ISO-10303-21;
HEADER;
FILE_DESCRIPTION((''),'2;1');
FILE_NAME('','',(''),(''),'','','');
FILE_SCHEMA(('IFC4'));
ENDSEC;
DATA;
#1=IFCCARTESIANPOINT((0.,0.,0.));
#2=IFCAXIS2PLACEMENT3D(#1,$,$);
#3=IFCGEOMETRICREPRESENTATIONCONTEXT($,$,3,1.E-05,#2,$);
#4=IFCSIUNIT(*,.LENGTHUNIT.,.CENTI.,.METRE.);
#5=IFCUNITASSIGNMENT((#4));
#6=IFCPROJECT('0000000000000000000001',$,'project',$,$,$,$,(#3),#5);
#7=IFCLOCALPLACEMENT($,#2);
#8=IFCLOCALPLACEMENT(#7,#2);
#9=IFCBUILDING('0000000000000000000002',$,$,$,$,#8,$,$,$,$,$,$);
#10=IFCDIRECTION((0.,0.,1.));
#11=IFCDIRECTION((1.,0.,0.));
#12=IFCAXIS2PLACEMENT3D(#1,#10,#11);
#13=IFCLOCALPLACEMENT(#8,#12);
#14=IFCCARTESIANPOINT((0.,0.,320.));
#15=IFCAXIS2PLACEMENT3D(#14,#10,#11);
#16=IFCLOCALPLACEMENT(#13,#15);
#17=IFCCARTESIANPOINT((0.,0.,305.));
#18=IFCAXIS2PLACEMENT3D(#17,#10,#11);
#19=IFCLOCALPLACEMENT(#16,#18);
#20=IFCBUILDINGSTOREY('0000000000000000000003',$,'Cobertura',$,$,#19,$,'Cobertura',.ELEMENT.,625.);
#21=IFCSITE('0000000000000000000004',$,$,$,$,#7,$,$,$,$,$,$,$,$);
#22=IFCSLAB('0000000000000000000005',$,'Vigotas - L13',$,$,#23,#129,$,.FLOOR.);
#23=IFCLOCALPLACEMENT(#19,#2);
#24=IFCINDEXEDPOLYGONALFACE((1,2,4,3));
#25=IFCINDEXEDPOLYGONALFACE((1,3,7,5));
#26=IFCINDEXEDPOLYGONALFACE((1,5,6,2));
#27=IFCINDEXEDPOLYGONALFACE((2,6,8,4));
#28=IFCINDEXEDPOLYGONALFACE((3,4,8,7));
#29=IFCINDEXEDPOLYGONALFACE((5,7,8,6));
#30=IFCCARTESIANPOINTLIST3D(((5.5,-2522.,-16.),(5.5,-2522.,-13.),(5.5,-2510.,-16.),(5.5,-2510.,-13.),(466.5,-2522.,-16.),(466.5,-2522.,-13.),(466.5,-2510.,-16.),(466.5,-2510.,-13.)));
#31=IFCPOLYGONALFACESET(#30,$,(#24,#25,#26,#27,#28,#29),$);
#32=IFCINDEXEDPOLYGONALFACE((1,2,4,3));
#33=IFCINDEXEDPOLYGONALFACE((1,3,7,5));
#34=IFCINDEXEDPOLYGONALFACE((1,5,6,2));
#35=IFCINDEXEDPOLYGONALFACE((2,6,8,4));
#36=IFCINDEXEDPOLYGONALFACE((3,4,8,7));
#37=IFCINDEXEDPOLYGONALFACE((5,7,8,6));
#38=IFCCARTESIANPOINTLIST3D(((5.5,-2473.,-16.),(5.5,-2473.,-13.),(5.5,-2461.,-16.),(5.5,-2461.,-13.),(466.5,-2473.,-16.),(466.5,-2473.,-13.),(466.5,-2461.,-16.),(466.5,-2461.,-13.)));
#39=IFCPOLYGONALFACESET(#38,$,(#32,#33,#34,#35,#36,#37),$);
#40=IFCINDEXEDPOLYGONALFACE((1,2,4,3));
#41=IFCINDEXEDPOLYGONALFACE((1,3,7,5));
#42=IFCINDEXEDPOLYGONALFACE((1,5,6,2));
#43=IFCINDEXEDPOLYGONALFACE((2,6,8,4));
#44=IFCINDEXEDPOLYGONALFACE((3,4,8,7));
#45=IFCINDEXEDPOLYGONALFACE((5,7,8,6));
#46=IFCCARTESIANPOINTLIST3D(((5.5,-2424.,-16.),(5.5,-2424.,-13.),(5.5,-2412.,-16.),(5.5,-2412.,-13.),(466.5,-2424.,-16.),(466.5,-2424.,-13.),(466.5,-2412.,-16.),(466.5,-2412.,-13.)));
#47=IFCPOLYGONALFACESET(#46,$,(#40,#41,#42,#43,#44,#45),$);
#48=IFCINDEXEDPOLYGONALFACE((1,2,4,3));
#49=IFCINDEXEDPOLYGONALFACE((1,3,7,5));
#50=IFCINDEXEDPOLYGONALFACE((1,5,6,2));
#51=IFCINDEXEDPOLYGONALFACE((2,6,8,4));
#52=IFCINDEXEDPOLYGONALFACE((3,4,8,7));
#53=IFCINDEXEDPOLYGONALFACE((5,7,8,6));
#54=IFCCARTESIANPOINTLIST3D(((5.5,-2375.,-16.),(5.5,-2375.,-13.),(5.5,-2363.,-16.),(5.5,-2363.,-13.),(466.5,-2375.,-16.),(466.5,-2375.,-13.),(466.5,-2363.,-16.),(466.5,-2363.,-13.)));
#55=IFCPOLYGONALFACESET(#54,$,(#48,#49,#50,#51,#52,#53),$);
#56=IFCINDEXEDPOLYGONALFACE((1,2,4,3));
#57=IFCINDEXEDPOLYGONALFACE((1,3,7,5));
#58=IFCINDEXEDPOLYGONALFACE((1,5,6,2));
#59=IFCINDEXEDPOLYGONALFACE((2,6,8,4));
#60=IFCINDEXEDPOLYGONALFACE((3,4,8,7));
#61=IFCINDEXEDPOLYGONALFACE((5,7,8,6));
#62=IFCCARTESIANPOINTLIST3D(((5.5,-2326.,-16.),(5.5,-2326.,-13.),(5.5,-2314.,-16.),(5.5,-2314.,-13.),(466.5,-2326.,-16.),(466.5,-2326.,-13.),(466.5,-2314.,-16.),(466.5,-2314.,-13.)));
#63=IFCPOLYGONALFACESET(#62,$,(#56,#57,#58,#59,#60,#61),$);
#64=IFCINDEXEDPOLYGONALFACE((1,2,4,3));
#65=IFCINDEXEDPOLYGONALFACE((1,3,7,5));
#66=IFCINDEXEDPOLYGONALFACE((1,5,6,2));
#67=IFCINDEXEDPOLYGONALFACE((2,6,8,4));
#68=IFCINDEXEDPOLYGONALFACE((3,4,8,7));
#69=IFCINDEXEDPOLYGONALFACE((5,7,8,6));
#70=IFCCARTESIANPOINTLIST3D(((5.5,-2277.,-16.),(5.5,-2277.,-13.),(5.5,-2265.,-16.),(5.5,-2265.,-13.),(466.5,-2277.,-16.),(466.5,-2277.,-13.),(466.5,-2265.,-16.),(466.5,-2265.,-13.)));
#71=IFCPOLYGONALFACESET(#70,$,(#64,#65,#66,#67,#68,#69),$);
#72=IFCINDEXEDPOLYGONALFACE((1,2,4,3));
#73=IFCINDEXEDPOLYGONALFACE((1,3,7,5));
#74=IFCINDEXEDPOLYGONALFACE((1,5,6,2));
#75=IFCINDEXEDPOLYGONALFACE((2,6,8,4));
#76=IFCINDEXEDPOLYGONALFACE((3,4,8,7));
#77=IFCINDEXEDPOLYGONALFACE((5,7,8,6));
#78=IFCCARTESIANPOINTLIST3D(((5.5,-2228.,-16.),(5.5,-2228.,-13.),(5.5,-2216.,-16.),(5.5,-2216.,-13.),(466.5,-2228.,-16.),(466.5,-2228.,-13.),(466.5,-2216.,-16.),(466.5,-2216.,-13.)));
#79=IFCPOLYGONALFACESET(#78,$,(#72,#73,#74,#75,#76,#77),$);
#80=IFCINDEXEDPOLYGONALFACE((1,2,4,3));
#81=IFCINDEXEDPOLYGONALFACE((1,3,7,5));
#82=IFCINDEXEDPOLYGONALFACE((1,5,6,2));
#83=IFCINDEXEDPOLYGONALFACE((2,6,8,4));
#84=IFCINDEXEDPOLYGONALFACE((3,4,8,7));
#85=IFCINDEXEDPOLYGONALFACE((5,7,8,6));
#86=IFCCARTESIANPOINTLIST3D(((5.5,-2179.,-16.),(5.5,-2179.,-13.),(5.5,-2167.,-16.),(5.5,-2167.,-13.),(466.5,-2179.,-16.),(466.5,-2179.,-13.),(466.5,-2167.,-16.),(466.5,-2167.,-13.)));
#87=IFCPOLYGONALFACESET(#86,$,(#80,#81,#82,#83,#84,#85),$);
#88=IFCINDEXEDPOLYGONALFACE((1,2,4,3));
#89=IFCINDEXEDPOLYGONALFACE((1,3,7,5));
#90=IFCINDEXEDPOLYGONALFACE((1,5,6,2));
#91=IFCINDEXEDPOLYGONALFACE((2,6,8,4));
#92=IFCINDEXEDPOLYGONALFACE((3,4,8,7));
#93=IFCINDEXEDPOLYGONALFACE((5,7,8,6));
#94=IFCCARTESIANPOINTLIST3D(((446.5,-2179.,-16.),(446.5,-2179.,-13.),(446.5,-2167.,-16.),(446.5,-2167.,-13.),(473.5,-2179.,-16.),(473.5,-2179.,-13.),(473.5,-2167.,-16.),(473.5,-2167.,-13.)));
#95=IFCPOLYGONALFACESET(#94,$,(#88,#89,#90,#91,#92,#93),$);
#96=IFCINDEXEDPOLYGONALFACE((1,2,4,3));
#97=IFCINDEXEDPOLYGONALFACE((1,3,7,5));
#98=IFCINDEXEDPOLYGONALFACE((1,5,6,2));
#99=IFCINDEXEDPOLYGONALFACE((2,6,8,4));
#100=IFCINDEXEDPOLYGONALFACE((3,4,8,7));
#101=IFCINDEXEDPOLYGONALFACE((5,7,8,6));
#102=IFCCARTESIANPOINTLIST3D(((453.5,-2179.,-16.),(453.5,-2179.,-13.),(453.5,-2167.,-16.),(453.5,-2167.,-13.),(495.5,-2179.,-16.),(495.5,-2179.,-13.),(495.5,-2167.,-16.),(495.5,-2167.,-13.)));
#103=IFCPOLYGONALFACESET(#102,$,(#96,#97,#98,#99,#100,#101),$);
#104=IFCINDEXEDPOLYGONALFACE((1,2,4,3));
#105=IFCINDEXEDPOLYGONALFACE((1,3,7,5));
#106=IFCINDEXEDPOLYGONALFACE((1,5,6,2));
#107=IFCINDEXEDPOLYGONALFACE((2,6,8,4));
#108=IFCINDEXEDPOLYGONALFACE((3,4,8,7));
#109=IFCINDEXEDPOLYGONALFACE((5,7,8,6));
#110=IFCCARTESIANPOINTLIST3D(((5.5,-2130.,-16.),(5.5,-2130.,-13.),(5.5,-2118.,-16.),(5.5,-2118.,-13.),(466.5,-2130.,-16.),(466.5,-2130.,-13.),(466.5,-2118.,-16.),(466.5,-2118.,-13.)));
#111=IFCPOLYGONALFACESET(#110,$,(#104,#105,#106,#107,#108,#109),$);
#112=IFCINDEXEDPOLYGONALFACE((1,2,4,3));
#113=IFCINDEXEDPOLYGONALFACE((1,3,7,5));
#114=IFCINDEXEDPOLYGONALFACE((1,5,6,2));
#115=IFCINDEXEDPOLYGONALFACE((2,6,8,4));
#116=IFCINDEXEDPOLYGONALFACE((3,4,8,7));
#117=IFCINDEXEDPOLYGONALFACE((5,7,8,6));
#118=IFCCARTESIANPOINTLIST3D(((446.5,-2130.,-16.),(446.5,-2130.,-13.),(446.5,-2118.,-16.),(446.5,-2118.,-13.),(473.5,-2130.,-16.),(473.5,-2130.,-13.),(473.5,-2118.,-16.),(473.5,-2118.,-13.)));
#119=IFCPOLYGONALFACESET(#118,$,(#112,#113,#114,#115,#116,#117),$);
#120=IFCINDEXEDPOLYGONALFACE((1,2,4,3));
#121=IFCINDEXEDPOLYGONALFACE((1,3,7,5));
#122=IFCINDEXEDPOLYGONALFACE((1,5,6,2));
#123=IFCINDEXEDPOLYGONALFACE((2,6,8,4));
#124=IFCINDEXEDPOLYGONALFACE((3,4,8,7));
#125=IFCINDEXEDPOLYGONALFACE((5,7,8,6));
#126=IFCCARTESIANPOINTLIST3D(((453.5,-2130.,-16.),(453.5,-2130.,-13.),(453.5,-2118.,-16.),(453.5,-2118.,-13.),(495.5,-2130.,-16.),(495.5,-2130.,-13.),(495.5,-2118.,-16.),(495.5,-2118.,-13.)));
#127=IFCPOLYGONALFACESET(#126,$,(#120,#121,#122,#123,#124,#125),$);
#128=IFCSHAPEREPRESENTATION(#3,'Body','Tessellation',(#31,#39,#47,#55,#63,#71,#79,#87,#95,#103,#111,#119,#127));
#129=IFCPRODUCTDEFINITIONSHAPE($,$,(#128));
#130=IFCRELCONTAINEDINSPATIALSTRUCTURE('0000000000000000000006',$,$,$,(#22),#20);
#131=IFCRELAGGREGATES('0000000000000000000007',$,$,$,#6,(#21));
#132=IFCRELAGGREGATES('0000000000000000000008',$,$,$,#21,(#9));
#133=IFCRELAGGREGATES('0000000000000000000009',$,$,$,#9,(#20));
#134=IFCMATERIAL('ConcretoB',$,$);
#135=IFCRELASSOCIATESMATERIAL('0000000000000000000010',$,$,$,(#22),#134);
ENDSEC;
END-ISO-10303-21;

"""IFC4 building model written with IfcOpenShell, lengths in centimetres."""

from ifc_helpers import new_model, si_unit, frame, origin, origin_with_axes, place, context, project, spatial, polyline, outline, extrude, material, element, save


model = new_model("IFC4")

# Units and contexts
context_of_model = context(None, 3, precision=1e-05, world=origin())
ifc_project = project(units=[si_unit("LENGTHUNIT", "METRE", prefix="CENTI")], contexts=[context_of_model])

# Site, building, storey
site_placement = place(None, origin())
site = spatial("IfcSite", under=ifc_project, at=site_placement)
building_placement = place(site_placement, origin())
building = spatial("IfcBuilding", under=site, at=building_placement)
placement_1 = place(building_placement, origin_with_axes())
placement_2 = place(placement_1, frame((0.0, 0.0, 320.0), z_axis=(0.0, 0.0, 1.0), x_axis=(1.0, 0.0, 0.0)))
storey_placement = place(placement_2, frame((0.0, 0.0, 305.0), z_axis=(0.0, 0.0, 1.0), x_axis=(1.0, 0.0, 0.0)))
storey = spatial("IfcBuildingStorey", under=building, at=storey_placement, Name="Cobertura", LongName="Cobertura", CompositionType="ELEMENT", Elevation=625.0)

# Shared definitions
ifc_material = material(Name="ConcretoB")

# Slab
slab_1_placement = place(storey_placement, frame((250.5, -2320.0, -13.0), z_axis=(0.0, 0.0, 1.0), x_axis=(1.0, 0.0, 0.0)))
element("IfcSlab", 1, at=slab_1_placement, inside=storey, material=ifc_material, Name="Vigotas - L13", PredefinedType="FLOOR", context=context_of_model, shape_type="SolidModel", body=[
    extrude(outline(polyline([(6.0, 1.5), (-6.0, 1.5), (-6.0, -1.5), (6.0, -1.5), (6.0, 1.5), (6.0, 1.5)])), frame((-245.0, -196.0, -1.5), z_axis=(1.0, 0.0, 0.0), x_axis=(0.0, -1.0, 0.0)), (0.0, 0.0, 1.0), 461.0),
    extrude(outline(polyline([(6.0, 1.5), (-6.0, 1.5), (-6.0, -1.5), (6.0, -1.5), (6.0, 1.5), (6.0, 1.5)])), frame((-245.0, -147.0, -1.5), z_axis=(1.0, 0.0, 0.0), x_axis=(0.0, -1.0, 0.0)), (0.0, 0.0, 1.0), 461.0),
    extrude(outline(polyline([(6.0, 1.5), (-6.0, 1.5), (-6.0, -1.5), (6.0, -1.5), (6.0, 1.5), (6.0, 1.5)])), frame((-245.0, -98.0, -1.5), z_axis=(1.0, 0.0, 0.0), x_axis=(0.0, -1.0, 0.0)), (0.0, 0.0, 1.0), 461.0),
    extrude(outline(polyline([(6.0, 1.5), (-6.0, 1.5), (-6.0, -1.5), (6.0, -1.5), (6.0, 1.5), (6.0, 1.5)])), frame((-245.0, -49.0, -1.5), z_axis=(1.0, 0.0, 0.0), x_axis=(0.0, -1.0, 0.0)), (0.0, 0.0, 1.0), 461.0),
    extrude(outline(polyline([(6.0, 1.5), (-6.0, 1.5), (-6.0, -1.5), (6.0, -1.5), (6.0, 1.5), (6.0, 1.5)])), frame((-245.0, 0.0, -1.5), z_axis=(1.0, 0.0, 0.0), x_axis=(0.0, -1.0, 0.0)), (0.0, 0.0, 1.0), 461.0),
    extrude(outline(polyline([(6.0, 1.5), (-6.0, 1.5), (-6.0, -1.5), (6.0, -1.5), (6.0, 1.5), (6.0, 1.5)])), frame((-245.0, 49.0, -1.5), z_axis=(1.0, 0.0, 0.0), x_axis=(0.0, -1.0, 0.0)), (0.0, 0.0, 1.0), 461.0),
    extrude(outline(polyline([(6.0, 1.5), (-6.0, 1.5), (-6.0, -1.5), (6.0, -1.5), (6.0, 1.5), (6.0, 1.5)])), frame((-245.0, 98.0, -1.5), z_axis=(1.0, 0.0, 0.0), x_axis=(0.0, -1.0, 0.0)), (0.0, 0.0, 1.0), 461.0),
    extrude(outline(polyline([(6.0, 1.5), (-6.0, 1.5), (-6.0, -1.5), (6.0, -1.5), (6.0, 1.5), (6.0, 1.5)])), frame((-245.0, 147.0, -1.5), z_axis=(1.0, 0.0, 0.0), x_axis=(0.0, -1.0, 0.0)), (0.0, 0.0, 1.0), 461.0),
    extrude(outline(polyline([(6.0, 1.5), (-6.0, 1.5), (-6.0, -1.5), (6.0, -1.5), (6.0, 1.5), (6.0, 1.5)])), frame((196.0, 147.0, -1.5), z_axis=(1.0, 0.0, 0.0), x_axis=(0.0, -1.0, 0.0)), (0.0, 0.0, 1.0), 27.0),
    extrude(outline(polyline([(6.0, 1.5), (-6.0, 1.5), (-6.0, -1.5), (6.0, -1.5), (6.0, 1.5), (6.0, 1.5)])), frame((203.0, 147.0, -1.5), z_axis=(1.0, 0.0, 0.0), x_axis=(0.0, -1.0, 0.0)), (0.0, 0.0, 1.0), 42.0),
    extrude(outline(polyline([(6.0, 1.5), (-6.0, 1.5), (-6.0, -1.5), (6.0, -1.5), (6.0, 1.5), (6.0, 1.5)])), frame((-245.0, 196.0, -1.5), z_axis=(1.0, 0.0, 0.0), x_axis=(0.0, -1.0, 0.0)), (0.0, 0.0, 1.0), 461.0),
    extrude(outline(polyline([(6.0, 1.5), (-6.0, 1.5), (-6.0, -1.5), (6.0, -1.5), (6.0, 1.5), (6.0, 1.5)])), frame((196.0, 196.0, -1.5), z_axis=(1.0, 0.0, 0.0), x_axis=(0.0, -1.0, 0.0)), (0.0, 0.0, 1.0), 27.0),
    extrude(outline(polyline([(6.0, 1.5), (-6.0, 1.5), (-6.0, -1.5), (6.0, -1.5), (6.0, 1.5), (6.0, 1.5)])), frame((203.0, 196.0, -1.5), z_axis=(1.0, 0.0, 0.0), x_axis=(0.0, -1.0, 0.0)), (0.0, 0.0, 1.0), 42.0),
])

save(model, "model.ifc")
